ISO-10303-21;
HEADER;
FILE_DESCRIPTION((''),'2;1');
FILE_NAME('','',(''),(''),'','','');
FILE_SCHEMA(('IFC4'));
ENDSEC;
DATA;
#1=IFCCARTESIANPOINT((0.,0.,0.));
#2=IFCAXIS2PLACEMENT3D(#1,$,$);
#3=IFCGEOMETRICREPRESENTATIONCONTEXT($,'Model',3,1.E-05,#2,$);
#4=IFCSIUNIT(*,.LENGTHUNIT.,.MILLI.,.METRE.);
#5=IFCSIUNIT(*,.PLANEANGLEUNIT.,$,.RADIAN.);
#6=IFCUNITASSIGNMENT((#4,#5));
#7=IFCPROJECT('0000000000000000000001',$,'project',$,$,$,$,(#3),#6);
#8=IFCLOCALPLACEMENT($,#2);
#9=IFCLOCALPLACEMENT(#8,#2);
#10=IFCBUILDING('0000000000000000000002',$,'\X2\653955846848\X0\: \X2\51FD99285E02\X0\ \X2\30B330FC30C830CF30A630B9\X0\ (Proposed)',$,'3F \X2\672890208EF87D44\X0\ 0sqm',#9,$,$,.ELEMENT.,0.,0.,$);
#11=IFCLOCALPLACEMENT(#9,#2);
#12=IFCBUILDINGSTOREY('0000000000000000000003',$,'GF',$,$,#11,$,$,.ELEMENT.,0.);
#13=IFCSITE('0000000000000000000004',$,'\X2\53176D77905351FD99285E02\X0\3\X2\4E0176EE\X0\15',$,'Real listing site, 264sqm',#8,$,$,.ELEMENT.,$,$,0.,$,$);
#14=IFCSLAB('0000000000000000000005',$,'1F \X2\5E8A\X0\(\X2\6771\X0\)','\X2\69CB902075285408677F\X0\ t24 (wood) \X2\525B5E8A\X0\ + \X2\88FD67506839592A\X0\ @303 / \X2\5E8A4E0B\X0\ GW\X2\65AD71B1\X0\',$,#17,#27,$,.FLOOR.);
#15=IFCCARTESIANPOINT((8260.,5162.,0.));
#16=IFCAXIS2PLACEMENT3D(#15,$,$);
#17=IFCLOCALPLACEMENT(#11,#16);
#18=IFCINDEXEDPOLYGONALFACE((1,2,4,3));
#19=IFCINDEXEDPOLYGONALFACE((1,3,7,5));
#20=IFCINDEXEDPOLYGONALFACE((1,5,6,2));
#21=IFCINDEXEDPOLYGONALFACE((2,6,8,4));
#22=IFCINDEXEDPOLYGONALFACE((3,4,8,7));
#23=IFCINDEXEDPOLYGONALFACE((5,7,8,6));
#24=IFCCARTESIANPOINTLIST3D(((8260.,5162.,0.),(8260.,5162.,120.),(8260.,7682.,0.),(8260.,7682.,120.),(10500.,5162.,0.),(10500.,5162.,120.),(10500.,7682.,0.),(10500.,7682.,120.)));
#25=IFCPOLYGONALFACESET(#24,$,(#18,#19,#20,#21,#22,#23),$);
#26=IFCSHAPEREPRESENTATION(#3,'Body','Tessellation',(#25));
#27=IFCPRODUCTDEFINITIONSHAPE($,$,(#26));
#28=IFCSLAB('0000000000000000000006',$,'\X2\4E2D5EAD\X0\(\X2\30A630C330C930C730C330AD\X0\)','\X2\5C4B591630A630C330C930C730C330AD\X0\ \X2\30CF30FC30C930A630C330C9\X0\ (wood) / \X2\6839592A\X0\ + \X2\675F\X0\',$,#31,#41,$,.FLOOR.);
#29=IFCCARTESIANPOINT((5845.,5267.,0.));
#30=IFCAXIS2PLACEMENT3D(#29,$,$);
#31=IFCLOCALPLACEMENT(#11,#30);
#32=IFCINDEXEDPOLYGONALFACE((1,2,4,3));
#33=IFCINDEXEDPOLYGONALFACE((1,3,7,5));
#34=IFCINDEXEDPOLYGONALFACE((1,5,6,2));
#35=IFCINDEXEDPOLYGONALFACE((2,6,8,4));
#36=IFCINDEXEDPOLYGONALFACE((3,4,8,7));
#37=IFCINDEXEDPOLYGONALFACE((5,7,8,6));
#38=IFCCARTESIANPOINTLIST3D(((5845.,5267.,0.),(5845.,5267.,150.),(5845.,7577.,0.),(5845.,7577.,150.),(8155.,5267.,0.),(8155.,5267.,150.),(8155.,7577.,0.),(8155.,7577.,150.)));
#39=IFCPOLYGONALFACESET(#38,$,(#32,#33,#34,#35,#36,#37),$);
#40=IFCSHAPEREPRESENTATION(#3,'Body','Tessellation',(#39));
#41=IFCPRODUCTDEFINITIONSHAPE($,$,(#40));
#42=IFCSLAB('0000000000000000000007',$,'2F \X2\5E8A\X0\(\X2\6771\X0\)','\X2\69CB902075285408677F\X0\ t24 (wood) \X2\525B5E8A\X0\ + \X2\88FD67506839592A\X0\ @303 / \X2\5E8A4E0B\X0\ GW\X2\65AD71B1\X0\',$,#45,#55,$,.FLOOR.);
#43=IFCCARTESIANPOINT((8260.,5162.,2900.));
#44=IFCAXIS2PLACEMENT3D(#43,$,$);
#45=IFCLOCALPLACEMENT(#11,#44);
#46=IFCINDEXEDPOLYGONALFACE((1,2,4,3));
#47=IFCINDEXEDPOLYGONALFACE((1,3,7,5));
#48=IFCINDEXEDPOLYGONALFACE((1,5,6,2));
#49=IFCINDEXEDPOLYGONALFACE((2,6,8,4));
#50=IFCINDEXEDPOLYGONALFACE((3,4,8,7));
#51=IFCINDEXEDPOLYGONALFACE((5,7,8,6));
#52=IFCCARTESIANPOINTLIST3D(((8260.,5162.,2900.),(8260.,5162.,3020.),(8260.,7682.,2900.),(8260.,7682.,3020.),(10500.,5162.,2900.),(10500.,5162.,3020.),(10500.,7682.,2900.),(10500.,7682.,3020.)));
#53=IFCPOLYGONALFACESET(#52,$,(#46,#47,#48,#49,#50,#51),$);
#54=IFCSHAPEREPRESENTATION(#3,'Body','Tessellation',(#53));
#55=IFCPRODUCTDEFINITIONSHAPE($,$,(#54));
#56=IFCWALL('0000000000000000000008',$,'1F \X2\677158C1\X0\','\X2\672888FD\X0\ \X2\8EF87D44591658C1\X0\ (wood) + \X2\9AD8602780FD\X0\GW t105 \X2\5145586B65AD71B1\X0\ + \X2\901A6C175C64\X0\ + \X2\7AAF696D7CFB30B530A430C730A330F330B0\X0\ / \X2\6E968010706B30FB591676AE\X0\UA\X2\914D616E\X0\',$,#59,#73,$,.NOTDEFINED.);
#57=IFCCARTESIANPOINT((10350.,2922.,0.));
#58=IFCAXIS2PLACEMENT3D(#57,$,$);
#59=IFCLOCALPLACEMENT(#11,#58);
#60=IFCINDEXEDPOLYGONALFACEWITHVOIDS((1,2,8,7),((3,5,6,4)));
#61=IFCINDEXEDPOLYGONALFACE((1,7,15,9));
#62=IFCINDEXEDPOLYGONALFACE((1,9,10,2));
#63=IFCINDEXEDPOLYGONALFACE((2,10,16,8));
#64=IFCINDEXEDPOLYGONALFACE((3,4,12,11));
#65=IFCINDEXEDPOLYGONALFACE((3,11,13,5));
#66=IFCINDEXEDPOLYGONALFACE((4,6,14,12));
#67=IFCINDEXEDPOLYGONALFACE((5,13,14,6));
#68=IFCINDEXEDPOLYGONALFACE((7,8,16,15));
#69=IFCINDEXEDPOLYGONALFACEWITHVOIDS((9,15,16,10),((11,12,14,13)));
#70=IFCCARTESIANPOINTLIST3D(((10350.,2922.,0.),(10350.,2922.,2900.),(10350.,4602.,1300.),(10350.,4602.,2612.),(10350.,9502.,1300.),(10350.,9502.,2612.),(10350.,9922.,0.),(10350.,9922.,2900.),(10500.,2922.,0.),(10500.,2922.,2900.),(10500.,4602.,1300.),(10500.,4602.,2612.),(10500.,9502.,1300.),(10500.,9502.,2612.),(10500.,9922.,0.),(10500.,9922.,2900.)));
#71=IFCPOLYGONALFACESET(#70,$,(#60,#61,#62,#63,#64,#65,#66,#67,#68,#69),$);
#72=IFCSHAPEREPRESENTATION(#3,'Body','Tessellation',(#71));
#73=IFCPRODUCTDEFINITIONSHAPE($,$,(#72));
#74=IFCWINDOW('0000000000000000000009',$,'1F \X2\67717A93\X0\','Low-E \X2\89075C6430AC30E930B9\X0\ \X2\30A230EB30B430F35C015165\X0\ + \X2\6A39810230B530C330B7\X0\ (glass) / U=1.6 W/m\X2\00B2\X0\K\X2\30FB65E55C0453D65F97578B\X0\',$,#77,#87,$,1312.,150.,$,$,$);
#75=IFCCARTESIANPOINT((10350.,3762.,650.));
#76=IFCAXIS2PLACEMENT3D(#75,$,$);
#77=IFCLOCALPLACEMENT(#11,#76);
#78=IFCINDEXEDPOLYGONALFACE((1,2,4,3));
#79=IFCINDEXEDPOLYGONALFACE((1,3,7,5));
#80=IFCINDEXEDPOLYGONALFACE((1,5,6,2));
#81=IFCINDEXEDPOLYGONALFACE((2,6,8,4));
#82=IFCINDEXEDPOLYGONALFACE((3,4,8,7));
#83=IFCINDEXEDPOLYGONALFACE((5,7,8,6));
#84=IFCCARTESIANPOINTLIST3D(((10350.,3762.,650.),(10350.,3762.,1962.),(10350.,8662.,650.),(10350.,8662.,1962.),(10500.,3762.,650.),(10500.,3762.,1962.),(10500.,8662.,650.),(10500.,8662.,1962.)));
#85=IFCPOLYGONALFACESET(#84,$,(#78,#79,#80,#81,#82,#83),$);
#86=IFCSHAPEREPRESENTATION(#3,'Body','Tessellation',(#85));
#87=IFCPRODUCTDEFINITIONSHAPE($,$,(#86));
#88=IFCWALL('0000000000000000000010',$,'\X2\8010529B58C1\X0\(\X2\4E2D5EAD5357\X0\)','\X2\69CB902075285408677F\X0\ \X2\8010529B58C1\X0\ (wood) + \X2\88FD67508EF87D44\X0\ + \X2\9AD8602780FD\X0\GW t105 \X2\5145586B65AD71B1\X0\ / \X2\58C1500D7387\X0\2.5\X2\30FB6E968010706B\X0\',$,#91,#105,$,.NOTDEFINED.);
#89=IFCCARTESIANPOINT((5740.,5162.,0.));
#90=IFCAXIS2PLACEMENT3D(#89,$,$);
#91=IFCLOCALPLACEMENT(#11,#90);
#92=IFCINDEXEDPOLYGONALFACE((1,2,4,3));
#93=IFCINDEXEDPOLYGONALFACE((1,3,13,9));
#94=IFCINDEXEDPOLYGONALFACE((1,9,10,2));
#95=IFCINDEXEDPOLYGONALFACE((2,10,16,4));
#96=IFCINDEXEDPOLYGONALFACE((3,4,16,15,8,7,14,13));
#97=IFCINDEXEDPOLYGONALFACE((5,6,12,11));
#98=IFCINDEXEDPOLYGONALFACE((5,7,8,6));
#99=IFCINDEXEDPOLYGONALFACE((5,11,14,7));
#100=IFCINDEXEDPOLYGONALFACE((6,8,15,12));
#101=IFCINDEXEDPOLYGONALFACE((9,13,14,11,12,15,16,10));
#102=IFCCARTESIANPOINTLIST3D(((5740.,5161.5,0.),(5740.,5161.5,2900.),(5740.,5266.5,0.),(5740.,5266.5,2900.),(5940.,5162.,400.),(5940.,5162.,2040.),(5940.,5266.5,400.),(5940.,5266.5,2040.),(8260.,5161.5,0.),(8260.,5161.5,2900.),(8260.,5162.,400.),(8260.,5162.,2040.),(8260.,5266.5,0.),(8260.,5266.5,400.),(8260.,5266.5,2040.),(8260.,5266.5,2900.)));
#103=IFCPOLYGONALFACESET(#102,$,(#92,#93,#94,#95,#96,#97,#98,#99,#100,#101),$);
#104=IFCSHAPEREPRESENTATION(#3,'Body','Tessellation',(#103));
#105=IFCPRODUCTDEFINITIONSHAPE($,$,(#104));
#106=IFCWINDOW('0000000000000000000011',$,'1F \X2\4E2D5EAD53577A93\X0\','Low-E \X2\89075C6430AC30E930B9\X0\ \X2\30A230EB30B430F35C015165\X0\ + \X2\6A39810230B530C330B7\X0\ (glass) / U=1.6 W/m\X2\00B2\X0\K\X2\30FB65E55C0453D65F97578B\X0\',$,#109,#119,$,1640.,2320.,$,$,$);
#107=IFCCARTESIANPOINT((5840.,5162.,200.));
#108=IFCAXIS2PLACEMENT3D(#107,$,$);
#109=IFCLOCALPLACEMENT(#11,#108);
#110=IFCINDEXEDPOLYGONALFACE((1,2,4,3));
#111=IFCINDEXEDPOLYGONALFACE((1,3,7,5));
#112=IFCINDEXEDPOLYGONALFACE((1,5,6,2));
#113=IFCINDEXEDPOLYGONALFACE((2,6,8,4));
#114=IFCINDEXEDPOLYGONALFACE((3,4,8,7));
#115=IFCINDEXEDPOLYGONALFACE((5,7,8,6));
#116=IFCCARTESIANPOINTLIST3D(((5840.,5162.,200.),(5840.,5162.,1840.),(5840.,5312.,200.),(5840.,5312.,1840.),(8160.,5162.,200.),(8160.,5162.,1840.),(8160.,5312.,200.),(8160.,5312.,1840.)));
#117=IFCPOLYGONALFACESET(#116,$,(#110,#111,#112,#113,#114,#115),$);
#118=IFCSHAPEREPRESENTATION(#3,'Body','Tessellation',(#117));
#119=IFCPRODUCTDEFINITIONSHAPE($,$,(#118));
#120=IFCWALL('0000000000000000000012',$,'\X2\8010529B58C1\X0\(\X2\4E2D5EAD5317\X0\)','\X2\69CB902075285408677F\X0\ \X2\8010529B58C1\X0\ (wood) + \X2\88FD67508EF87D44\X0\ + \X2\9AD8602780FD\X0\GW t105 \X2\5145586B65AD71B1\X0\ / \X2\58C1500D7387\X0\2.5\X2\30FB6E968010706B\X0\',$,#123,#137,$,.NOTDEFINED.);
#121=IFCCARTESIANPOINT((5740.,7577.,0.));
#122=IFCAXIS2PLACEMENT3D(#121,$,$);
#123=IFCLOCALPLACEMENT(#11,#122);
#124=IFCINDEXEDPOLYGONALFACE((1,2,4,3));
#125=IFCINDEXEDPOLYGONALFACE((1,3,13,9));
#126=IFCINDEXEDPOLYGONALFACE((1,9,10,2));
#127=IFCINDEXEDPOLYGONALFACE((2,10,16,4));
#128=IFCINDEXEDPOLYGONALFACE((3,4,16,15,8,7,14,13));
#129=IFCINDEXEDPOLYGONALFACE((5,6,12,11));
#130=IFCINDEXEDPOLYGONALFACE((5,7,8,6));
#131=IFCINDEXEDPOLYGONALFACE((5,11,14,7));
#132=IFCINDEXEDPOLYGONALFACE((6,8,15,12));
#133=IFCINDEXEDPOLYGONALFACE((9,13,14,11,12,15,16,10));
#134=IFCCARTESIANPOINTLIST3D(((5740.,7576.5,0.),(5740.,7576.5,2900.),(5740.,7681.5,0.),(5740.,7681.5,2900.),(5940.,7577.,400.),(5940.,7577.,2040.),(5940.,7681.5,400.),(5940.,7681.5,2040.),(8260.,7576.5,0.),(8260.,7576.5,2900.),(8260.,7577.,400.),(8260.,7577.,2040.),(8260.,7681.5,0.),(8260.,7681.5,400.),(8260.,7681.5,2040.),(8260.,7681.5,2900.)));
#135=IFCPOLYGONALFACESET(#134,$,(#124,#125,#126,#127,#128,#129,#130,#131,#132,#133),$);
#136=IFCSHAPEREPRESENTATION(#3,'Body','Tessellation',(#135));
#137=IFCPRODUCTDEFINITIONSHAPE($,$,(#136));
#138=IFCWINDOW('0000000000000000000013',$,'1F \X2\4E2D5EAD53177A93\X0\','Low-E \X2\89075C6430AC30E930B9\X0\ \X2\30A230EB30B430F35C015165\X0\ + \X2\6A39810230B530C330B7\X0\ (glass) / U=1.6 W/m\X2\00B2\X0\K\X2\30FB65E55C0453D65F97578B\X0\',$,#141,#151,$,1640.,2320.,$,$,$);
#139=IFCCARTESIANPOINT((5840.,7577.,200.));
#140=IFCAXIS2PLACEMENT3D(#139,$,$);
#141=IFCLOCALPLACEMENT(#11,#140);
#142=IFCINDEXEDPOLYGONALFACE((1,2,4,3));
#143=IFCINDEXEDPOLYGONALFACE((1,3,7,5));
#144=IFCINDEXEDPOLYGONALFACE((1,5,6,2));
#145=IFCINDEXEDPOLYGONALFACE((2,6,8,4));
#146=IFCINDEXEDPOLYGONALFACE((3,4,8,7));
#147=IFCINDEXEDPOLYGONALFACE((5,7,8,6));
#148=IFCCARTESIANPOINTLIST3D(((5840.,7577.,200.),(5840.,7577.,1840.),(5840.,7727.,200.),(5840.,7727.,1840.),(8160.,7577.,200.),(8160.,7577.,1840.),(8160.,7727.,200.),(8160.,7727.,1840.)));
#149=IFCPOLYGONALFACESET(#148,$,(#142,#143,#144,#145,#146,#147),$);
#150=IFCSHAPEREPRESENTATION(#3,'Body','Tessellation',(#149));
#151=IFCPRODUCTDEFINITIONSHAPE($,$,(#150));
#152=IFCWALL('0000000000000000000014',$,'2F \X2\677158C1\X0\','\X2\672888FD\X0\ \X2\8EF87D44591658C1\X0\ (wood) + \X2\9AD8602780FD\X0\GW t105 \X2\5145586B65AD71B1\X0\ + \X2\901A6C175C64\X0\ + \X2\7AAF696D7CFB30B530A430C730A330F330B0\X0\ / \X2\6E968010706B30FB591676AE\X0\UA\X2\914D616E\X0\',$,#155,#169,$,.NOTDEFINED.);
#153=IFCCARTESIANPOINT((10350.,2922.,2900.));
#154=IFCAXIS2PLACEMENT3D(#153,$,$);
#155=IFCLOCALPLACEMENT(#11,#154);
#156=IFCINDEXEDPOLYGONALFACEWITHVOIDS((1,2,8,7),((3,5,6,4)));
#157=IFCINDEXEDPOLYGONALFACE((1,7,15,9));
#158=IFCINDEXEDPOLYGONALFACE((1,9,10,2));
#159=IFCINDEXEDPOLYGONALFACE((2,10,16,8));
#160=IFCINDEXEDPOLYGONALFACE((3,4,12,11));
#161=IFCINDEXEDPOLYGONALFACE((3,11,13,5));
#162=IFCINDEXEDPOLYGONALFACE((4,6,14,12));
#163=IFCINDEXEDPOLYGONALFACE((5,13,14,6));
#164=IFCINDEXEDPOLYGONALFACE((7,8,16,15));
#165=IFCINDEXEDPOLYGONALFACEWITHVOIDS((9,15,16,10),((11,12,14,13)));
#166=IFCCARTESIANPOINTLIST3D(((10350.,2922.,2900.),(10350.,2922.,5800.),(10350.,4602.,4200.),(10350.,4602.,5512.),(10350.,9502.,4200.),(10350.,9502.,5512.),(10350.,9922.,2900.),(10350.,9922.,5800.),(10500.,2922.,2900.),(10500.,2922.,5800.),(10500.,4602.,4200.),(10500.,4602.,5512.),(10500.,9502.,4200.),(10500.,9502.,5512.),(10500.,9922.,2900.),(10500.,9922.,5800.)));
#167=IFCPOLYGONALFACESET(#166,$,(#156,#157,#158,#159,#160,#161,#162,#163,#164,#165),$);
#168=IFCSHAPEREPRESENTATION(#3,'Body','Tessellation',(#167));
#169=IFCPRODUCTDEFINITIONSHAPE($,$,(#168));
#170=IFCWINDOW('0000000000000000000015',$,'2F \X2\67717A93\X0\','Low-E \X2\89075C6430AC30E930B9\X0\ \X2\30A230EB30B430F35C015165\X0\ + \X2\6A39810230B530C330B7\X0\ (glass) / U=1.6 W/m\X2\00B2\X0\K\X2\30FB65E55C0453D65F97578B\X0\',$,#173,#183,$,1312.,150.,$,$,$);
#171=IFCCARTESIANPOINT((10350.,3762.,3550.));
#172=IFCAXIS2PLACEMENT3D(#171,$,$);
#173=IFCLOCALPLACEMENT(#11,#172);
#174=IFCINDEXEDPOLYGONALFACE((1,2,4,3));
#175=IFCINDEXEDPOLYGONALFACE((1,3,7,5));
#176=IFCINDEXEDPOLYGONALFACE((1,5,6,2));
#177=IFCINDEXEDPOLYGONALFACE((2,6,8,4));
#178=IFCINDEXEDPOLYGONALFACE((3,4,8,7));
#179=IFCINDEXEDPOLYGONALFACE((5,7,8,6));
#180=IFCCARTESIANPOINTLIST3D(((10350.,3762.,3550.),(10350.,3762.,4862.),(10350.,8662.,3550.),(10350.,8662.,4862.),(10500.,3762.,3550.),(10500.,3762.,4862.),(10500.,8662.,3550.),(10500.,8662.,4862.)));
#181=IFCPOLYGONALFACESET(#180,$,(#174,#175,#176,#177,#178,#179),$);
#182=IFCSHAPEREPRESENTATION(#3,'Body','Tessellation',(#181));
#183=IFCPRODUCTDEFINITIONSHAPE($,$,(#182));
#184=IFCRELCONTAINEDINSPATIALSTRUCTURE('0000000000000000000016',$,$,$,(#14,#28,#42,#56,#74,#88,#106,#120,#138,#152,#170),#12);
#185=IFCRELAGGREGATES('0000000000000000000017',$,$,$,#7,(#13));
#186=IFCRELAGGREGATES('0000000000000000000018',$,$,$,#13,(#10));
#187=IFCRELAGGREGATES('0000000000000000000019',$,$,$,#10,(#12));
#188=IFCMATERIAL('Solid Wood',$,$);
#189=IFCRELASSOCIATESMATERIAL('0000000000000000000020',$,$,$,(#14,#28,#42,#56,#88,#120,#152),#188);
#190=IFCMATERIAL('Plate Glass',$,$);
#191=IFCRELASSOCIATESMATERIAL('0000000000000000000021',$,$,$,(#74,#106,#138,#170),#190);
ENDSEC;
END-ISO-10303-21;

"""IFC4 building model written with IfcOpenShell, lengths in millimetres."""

from ifc_helpers import new_model, si_unit, frame, frame_2d, origin, place, context, project, spatial, rectangle, extrude, material, element, fill, save


model = new_model("IFC4")

# Units and contexts
model_context = context("Model", 3, precision=1e-05, world=origin())
ifc_project = project(units=[si_unit("LENGTHUNIT", "METRE", prefix="MILLI"), si_unit("PLANEANGLEUNIT", "RADIAN")], contexts=[model_context])

# Site, building, storey
site_placement = place(None, origin())
site = spatial("IfcSite", under=ifc_project, at=site_placement, Name="北海道函館市3丁目15", ObjectType="Real listing site, 264sqm", CompositionType="ELEMENT", RefElevation=0.0)
building_placement = place(site_placement, origin())
building = spatial("IfcBuilding", under=site, at=building_placement, Name="改善案: 函館市 コートハウス (Proposed)", ObjectType="3F 木造軸組 0sqm", CompositionType="ELEMENT", ElevationOfRefHeight=0.0, ElevationOfTerrain=0.0)
storey_placement = place(building_placement, origin())
storey = spatial("IfcBuildingStorey", under=building, at=storey_placement, Name="GF", CompositionType="ELEMENT", Elevation=0.0)

# Slabs
ifc_material_1 = material(Name="Solid Wood")
slab_1_placement = place(storey_placement, frame((8260.0, 5162.0, 0.0)))
element("IfcSlab", 1, at=slab_1_placement, inside=storey, material=ifc_material_1, Name="1F 床(東)", Description="構造用合板 t24 (wood) 剛床 + 製材根太 @303 / 床下 GW断熱", PredefinedType="FLOOR", context=model_context, shape_type="SweptSolid", body=[
    extrude(rectangle(XDim=2240.0, YDim=2520.0, at=frame_2d((1120.0, 1260.0))), frame((8260.0, 5162.0, 0.0)), (0.0, 0.0, 1.0), 120.0),
])
slab_2_placement = place(storey_placement, frame((5845.0, 5267.0, 0.0)))
element("IfcSlab", 2, at=slab_2_placement, inside=storey, material=ifc_material_1, Name="中庭(ウッドデッキ)", Description="屋外ウッドデッキ ハードウッド (wood) / 根太 + 束", PredefinedType="FLOOR", context=model_context, shape_type="SweptSolid", body=[
    extrude(rectangle(XDim=2310.0, YDim=2310.0, at=frame_2d((1155.0, 1155.0))), frame((5845.0, 5267.0, 0.0)), (0.0, 0.0, 1.0), 150.0),
])
slab_3_placement = place(storey_placement, frame((8260.0, 5162.0, 2900.0)))
element("IfcSlab", 3, at=slab_3_placement, inside=storey, material=ifc_material_1, Name="2F 床(東)", Description="構造用合板 t24 (wood) 剛床 + 製材根太 @303 / 床下 GW断熱", PredefinedType="FLOOR", context=model_context, shape_type="SweptSolid", body=[
    extrude(rectangle(XDim=2240.0, YDim=2520.0, at=frame_2d((1120.0, 1260.0))), frame((8260.0, 5162.0, 2900.0)), (0.0, 0.0, 1.0), 120.0),
])

# Walls, openings, windows
wall_1_placement = place(storey_placement, frame((10350.0, 2922.0, 0.0)))
wall_1 = element("IfcWall", 4, at=wall_1_placement, inside=storey, material=ifc_material_1, Name="1F 東壁", Description="木製 軸組外壁 (wood) + 高性能GW t105 充填断熱 + 通気層 + 窯業系サイディング / 準耐火・外皮UA配慮", PredefinedType="NOTDEFINED", context=model_context, shape_type="SweptSolid", body=[
    extrude(rectangle(XDim=150.0, YDim=7000.0, at=frame_2d((75.0, 3500.0))), frame((10350.0, 2922.0, 0.0)), (0.0, 0.0, 1.0), 2900.0),
])
opening_1_placement = place(storey_placement, frame((10350.0, 3762.0, 650.0)))
opening_1 = element("IfcOpeningElement", 5, at=opening_1_placement, cuts=wall_1, PredefinedType="NOTDEFINED", context=model_context, shape_type="SweptSolid", body=[
    extrude(rectangle(XDim=150.0, YDim=4900.0, at=frame_2d((75.0, 2450.0))), frame((10350.0, 3762.0, 650.0)), (0.0, 0.0, 1.0), 1312.0),
])
ifc_material_2 = material(Name="Plate Glass")
window_1_placement = place(storey_placement, frame((10350.0, 3762.0, 650.0)))
window_1 = element("IfcWindow", 6, at=window_1_placement, inside=storey, material=ifc_material_2, Name="1F 東窓", Description="Low-E 複層ガラス アルゴン封入 + 樹脂サッシ (glass) / U=1.6 W/m²K・日射取得型", OverallHeight=1312.0, OverallWidth=150.0, context=model_context, shape_type="SweptSolid", body=[
    extrude(rectangle(XDim=150.0, YDim=4900.0, at=frame_2d((75.0, 2450.0))), frame((10350.0, 3762.0, 650.0)), (0.0, 0.0, 1.0), 1312.0),
])
fill(opening_1, window_1)
wall_2_placement = place(storey_placement, frame((5740.0, 5162.0, 0.0)))
wall_2 = element("IfcWall", 7, at=wall_2_placement, inside=storey, material=ifc_material_1, Name="耐力壁(中庭南)", Description="構造用合板 耐力壁 (wood) + 製材軸組 + 高性能GW t105 充填断熱 / 壁倍率2.5・準耐火", PredefinedType="NOTDEFINED", context=model_context, shape_type="SweptSolid", body=[
    extrude(rectangle(XDim=2520.0, YDim=105.0, at=frame_2d((1260.0, 52.0))), frame((5740.0, 5162.0, 0.0)), (0.0, 0.0, 1.0), 2900.0),
])
opening_2_placement = place(storey_placement, frame((5840.0, 5162.0, 200.0)))
opening_2 = element("IfcOpeningElement", 8, at=opening_2_placement, cuts=wall_2, PredefinedType="NOTDEFINED", context=model_context, shape_type="SweptSolid", body=[
    extrude(rectangle(XDim=2320.0, YDim=150.0, at=frame_2d((1160.0, 75.0))), frame((5840.0, 5162.0, 200.0)), (0.0, 0.0, 1.0), 1640.0),
])
window_2_placement = place(storey_placement, frame((5840.0, 5162.0, 200.0)))
window_2 = element("IfcWindow", 9, at=window_2_placement, inside=storey, material=ifc_material_2, Name="1F 中庭南窓", Description="Low-E 複層ガラス アルゴン封入 + 樹脂サッシ (glass) / U=1.6 W/m²K・日射取得型", OverallHeight=1640.0, OverallWidth=2320.0, context=model_context, shape_type="SweptSolid", body=[
    extrude(rectangle(XDim=2320.0, YDim=150.0, at=frame_2d((1160.0, 75.0))), frame((5840.0, 5162.0, 200.0)), (0.0, 0.0, 1.0), 1640.0),
])
fill(opening_2, window_2)
wall_3_placement = place(storey_placement, frame((5740.0, 7577.0, 0.0)))
wall_3 = element("IfcWall", 10, at=wall_3_placement, inside=storey, material=ifc_material_1, Name="耐力壁(中庭北)", Description="構造用合板 耐力壁 (wood) + 製材軸組 + 高性能GW t105 充填断熱 / 壁倍率2.5・準耐火", PredefinedType="NOTDEFINED", context=model_context, shape_type="SweptSolid", body=[
    extrude(rectangle(XDim=2520.0, YDim=105.0, at=frame_2d((1260.0, 52.0))), frame((5740.0, 7577.0, 0.0)), (0.0, 0.0, 1.0), 2900.0),
])
opening_3_placement = place(storey_placement, frame((5840.0, 7577.0, 200.0)))
opening_3 = element("IfcOpeningElement", 11, at=opening_3_placement, cuts=wall_3, PredefinedType="NOTDEFINED", context=model_context, shape_type="SweptSolid", body=[
    extrude(rectangle(XDim=2320.0, YDim=150.0, at=frame_2d((1160.0, 75.0))), frame((5840.0, 7577.0, 200.0)), (0.0, 0.0, 1.0), 1640.0),
])
window_3_placement = place(storey_placement, frame((5840.0, 7577.0, 200.0)))
window_3 = element("IfcWindow", 12, at=window_3_placement, inside=storey, material=ifc_material_2, Name="1F 中庭北窓", Description="Low-E 複層ガラス アルゴン封入 + 樹脂サッシ (glass) / U=1.6 W/m²K・日射取得型", OverallHeight=1640.0, OverallWidth=2320.0, context=model_context, shape_type="SweptSolid", body=[
    extrude(rectangle(XDim=2320.0, YDim=150.0, at=frame_2d((1160.0, 75.0))), frame((5840.0, 7577.0, 200.0)), (0.0, 0.0, 1.0), 1640.0),
])
fill(opening_3, window_3)

# Wall, opening, window
wall_4_placement = place(storey_placement, frame((10350.0, 2922.0, 2900.0)))
wall_4 = element("IfcWall", 13, at=wall_4_placement, inside=storey, material=ifc_material_1, Name="2F 東壁", Description="木製 軸組外壁 (wood) + 高性能GW t105 充填断熱 + 通気層 + 窯業系サイディング / 準耐火・外皮UA配慮", PredefinedType="NOTDEFINED", context=model_context, shape_type="SweptSolid", body=[
    extrude(rectangle(XDim=150.0, YDim=7000.0, at=frame_2d((75.0, 3500.0))), frame((10350.0, 2922.0, 2900.0)), (0.0, 0.0, 1.0), 2900.0),
])
opening_4_placement = place(storey_placement, frame((10350.0, 3762.0, 3550.0)))
opening_4 = element("IfcOpeningElement", 14, at=opening_4_placement, cuts=wall_4, PredefinedType="NOTDEFINED", context=model_context, shape_type="SweptSolid", body=[
    extrude(rectangle(XDim=150.0, YDim=4900.0, at=frame_2d((75.0, 2450.0))), frame((10350.0, 3762.0, 3550.0)), (0.0, 0.0, 1.0), 1312.0),
])
window_4_placement = place(storey_placement, frame((10350.0, 3762.0, 3550.0)))
window_4 = element("IfcWindow", 15, at=window_4_placement, inside=storey, material=ifc_material_2, Name="2F 東窓", Description="Low-E 複層ガラス アルゴン封入 + 樹脂サッシ (glass) / U=1.6 W/m²K・日射取得型", OverallHeight=1312.0, OverallWidth=150.0, context=model_context, shape_type="SweptSolid", body=[
    extrude(rectangle(XDim=150.0, YDim=4900.0, at=frame_2d((75.0, 2450.0))), frame((10350.0, 3762.0, 3550.0)), (0.0, 0.0, 1.0), 1312.0),
])
fill(opening_4, window_4)

save(model, "model.ifc")
